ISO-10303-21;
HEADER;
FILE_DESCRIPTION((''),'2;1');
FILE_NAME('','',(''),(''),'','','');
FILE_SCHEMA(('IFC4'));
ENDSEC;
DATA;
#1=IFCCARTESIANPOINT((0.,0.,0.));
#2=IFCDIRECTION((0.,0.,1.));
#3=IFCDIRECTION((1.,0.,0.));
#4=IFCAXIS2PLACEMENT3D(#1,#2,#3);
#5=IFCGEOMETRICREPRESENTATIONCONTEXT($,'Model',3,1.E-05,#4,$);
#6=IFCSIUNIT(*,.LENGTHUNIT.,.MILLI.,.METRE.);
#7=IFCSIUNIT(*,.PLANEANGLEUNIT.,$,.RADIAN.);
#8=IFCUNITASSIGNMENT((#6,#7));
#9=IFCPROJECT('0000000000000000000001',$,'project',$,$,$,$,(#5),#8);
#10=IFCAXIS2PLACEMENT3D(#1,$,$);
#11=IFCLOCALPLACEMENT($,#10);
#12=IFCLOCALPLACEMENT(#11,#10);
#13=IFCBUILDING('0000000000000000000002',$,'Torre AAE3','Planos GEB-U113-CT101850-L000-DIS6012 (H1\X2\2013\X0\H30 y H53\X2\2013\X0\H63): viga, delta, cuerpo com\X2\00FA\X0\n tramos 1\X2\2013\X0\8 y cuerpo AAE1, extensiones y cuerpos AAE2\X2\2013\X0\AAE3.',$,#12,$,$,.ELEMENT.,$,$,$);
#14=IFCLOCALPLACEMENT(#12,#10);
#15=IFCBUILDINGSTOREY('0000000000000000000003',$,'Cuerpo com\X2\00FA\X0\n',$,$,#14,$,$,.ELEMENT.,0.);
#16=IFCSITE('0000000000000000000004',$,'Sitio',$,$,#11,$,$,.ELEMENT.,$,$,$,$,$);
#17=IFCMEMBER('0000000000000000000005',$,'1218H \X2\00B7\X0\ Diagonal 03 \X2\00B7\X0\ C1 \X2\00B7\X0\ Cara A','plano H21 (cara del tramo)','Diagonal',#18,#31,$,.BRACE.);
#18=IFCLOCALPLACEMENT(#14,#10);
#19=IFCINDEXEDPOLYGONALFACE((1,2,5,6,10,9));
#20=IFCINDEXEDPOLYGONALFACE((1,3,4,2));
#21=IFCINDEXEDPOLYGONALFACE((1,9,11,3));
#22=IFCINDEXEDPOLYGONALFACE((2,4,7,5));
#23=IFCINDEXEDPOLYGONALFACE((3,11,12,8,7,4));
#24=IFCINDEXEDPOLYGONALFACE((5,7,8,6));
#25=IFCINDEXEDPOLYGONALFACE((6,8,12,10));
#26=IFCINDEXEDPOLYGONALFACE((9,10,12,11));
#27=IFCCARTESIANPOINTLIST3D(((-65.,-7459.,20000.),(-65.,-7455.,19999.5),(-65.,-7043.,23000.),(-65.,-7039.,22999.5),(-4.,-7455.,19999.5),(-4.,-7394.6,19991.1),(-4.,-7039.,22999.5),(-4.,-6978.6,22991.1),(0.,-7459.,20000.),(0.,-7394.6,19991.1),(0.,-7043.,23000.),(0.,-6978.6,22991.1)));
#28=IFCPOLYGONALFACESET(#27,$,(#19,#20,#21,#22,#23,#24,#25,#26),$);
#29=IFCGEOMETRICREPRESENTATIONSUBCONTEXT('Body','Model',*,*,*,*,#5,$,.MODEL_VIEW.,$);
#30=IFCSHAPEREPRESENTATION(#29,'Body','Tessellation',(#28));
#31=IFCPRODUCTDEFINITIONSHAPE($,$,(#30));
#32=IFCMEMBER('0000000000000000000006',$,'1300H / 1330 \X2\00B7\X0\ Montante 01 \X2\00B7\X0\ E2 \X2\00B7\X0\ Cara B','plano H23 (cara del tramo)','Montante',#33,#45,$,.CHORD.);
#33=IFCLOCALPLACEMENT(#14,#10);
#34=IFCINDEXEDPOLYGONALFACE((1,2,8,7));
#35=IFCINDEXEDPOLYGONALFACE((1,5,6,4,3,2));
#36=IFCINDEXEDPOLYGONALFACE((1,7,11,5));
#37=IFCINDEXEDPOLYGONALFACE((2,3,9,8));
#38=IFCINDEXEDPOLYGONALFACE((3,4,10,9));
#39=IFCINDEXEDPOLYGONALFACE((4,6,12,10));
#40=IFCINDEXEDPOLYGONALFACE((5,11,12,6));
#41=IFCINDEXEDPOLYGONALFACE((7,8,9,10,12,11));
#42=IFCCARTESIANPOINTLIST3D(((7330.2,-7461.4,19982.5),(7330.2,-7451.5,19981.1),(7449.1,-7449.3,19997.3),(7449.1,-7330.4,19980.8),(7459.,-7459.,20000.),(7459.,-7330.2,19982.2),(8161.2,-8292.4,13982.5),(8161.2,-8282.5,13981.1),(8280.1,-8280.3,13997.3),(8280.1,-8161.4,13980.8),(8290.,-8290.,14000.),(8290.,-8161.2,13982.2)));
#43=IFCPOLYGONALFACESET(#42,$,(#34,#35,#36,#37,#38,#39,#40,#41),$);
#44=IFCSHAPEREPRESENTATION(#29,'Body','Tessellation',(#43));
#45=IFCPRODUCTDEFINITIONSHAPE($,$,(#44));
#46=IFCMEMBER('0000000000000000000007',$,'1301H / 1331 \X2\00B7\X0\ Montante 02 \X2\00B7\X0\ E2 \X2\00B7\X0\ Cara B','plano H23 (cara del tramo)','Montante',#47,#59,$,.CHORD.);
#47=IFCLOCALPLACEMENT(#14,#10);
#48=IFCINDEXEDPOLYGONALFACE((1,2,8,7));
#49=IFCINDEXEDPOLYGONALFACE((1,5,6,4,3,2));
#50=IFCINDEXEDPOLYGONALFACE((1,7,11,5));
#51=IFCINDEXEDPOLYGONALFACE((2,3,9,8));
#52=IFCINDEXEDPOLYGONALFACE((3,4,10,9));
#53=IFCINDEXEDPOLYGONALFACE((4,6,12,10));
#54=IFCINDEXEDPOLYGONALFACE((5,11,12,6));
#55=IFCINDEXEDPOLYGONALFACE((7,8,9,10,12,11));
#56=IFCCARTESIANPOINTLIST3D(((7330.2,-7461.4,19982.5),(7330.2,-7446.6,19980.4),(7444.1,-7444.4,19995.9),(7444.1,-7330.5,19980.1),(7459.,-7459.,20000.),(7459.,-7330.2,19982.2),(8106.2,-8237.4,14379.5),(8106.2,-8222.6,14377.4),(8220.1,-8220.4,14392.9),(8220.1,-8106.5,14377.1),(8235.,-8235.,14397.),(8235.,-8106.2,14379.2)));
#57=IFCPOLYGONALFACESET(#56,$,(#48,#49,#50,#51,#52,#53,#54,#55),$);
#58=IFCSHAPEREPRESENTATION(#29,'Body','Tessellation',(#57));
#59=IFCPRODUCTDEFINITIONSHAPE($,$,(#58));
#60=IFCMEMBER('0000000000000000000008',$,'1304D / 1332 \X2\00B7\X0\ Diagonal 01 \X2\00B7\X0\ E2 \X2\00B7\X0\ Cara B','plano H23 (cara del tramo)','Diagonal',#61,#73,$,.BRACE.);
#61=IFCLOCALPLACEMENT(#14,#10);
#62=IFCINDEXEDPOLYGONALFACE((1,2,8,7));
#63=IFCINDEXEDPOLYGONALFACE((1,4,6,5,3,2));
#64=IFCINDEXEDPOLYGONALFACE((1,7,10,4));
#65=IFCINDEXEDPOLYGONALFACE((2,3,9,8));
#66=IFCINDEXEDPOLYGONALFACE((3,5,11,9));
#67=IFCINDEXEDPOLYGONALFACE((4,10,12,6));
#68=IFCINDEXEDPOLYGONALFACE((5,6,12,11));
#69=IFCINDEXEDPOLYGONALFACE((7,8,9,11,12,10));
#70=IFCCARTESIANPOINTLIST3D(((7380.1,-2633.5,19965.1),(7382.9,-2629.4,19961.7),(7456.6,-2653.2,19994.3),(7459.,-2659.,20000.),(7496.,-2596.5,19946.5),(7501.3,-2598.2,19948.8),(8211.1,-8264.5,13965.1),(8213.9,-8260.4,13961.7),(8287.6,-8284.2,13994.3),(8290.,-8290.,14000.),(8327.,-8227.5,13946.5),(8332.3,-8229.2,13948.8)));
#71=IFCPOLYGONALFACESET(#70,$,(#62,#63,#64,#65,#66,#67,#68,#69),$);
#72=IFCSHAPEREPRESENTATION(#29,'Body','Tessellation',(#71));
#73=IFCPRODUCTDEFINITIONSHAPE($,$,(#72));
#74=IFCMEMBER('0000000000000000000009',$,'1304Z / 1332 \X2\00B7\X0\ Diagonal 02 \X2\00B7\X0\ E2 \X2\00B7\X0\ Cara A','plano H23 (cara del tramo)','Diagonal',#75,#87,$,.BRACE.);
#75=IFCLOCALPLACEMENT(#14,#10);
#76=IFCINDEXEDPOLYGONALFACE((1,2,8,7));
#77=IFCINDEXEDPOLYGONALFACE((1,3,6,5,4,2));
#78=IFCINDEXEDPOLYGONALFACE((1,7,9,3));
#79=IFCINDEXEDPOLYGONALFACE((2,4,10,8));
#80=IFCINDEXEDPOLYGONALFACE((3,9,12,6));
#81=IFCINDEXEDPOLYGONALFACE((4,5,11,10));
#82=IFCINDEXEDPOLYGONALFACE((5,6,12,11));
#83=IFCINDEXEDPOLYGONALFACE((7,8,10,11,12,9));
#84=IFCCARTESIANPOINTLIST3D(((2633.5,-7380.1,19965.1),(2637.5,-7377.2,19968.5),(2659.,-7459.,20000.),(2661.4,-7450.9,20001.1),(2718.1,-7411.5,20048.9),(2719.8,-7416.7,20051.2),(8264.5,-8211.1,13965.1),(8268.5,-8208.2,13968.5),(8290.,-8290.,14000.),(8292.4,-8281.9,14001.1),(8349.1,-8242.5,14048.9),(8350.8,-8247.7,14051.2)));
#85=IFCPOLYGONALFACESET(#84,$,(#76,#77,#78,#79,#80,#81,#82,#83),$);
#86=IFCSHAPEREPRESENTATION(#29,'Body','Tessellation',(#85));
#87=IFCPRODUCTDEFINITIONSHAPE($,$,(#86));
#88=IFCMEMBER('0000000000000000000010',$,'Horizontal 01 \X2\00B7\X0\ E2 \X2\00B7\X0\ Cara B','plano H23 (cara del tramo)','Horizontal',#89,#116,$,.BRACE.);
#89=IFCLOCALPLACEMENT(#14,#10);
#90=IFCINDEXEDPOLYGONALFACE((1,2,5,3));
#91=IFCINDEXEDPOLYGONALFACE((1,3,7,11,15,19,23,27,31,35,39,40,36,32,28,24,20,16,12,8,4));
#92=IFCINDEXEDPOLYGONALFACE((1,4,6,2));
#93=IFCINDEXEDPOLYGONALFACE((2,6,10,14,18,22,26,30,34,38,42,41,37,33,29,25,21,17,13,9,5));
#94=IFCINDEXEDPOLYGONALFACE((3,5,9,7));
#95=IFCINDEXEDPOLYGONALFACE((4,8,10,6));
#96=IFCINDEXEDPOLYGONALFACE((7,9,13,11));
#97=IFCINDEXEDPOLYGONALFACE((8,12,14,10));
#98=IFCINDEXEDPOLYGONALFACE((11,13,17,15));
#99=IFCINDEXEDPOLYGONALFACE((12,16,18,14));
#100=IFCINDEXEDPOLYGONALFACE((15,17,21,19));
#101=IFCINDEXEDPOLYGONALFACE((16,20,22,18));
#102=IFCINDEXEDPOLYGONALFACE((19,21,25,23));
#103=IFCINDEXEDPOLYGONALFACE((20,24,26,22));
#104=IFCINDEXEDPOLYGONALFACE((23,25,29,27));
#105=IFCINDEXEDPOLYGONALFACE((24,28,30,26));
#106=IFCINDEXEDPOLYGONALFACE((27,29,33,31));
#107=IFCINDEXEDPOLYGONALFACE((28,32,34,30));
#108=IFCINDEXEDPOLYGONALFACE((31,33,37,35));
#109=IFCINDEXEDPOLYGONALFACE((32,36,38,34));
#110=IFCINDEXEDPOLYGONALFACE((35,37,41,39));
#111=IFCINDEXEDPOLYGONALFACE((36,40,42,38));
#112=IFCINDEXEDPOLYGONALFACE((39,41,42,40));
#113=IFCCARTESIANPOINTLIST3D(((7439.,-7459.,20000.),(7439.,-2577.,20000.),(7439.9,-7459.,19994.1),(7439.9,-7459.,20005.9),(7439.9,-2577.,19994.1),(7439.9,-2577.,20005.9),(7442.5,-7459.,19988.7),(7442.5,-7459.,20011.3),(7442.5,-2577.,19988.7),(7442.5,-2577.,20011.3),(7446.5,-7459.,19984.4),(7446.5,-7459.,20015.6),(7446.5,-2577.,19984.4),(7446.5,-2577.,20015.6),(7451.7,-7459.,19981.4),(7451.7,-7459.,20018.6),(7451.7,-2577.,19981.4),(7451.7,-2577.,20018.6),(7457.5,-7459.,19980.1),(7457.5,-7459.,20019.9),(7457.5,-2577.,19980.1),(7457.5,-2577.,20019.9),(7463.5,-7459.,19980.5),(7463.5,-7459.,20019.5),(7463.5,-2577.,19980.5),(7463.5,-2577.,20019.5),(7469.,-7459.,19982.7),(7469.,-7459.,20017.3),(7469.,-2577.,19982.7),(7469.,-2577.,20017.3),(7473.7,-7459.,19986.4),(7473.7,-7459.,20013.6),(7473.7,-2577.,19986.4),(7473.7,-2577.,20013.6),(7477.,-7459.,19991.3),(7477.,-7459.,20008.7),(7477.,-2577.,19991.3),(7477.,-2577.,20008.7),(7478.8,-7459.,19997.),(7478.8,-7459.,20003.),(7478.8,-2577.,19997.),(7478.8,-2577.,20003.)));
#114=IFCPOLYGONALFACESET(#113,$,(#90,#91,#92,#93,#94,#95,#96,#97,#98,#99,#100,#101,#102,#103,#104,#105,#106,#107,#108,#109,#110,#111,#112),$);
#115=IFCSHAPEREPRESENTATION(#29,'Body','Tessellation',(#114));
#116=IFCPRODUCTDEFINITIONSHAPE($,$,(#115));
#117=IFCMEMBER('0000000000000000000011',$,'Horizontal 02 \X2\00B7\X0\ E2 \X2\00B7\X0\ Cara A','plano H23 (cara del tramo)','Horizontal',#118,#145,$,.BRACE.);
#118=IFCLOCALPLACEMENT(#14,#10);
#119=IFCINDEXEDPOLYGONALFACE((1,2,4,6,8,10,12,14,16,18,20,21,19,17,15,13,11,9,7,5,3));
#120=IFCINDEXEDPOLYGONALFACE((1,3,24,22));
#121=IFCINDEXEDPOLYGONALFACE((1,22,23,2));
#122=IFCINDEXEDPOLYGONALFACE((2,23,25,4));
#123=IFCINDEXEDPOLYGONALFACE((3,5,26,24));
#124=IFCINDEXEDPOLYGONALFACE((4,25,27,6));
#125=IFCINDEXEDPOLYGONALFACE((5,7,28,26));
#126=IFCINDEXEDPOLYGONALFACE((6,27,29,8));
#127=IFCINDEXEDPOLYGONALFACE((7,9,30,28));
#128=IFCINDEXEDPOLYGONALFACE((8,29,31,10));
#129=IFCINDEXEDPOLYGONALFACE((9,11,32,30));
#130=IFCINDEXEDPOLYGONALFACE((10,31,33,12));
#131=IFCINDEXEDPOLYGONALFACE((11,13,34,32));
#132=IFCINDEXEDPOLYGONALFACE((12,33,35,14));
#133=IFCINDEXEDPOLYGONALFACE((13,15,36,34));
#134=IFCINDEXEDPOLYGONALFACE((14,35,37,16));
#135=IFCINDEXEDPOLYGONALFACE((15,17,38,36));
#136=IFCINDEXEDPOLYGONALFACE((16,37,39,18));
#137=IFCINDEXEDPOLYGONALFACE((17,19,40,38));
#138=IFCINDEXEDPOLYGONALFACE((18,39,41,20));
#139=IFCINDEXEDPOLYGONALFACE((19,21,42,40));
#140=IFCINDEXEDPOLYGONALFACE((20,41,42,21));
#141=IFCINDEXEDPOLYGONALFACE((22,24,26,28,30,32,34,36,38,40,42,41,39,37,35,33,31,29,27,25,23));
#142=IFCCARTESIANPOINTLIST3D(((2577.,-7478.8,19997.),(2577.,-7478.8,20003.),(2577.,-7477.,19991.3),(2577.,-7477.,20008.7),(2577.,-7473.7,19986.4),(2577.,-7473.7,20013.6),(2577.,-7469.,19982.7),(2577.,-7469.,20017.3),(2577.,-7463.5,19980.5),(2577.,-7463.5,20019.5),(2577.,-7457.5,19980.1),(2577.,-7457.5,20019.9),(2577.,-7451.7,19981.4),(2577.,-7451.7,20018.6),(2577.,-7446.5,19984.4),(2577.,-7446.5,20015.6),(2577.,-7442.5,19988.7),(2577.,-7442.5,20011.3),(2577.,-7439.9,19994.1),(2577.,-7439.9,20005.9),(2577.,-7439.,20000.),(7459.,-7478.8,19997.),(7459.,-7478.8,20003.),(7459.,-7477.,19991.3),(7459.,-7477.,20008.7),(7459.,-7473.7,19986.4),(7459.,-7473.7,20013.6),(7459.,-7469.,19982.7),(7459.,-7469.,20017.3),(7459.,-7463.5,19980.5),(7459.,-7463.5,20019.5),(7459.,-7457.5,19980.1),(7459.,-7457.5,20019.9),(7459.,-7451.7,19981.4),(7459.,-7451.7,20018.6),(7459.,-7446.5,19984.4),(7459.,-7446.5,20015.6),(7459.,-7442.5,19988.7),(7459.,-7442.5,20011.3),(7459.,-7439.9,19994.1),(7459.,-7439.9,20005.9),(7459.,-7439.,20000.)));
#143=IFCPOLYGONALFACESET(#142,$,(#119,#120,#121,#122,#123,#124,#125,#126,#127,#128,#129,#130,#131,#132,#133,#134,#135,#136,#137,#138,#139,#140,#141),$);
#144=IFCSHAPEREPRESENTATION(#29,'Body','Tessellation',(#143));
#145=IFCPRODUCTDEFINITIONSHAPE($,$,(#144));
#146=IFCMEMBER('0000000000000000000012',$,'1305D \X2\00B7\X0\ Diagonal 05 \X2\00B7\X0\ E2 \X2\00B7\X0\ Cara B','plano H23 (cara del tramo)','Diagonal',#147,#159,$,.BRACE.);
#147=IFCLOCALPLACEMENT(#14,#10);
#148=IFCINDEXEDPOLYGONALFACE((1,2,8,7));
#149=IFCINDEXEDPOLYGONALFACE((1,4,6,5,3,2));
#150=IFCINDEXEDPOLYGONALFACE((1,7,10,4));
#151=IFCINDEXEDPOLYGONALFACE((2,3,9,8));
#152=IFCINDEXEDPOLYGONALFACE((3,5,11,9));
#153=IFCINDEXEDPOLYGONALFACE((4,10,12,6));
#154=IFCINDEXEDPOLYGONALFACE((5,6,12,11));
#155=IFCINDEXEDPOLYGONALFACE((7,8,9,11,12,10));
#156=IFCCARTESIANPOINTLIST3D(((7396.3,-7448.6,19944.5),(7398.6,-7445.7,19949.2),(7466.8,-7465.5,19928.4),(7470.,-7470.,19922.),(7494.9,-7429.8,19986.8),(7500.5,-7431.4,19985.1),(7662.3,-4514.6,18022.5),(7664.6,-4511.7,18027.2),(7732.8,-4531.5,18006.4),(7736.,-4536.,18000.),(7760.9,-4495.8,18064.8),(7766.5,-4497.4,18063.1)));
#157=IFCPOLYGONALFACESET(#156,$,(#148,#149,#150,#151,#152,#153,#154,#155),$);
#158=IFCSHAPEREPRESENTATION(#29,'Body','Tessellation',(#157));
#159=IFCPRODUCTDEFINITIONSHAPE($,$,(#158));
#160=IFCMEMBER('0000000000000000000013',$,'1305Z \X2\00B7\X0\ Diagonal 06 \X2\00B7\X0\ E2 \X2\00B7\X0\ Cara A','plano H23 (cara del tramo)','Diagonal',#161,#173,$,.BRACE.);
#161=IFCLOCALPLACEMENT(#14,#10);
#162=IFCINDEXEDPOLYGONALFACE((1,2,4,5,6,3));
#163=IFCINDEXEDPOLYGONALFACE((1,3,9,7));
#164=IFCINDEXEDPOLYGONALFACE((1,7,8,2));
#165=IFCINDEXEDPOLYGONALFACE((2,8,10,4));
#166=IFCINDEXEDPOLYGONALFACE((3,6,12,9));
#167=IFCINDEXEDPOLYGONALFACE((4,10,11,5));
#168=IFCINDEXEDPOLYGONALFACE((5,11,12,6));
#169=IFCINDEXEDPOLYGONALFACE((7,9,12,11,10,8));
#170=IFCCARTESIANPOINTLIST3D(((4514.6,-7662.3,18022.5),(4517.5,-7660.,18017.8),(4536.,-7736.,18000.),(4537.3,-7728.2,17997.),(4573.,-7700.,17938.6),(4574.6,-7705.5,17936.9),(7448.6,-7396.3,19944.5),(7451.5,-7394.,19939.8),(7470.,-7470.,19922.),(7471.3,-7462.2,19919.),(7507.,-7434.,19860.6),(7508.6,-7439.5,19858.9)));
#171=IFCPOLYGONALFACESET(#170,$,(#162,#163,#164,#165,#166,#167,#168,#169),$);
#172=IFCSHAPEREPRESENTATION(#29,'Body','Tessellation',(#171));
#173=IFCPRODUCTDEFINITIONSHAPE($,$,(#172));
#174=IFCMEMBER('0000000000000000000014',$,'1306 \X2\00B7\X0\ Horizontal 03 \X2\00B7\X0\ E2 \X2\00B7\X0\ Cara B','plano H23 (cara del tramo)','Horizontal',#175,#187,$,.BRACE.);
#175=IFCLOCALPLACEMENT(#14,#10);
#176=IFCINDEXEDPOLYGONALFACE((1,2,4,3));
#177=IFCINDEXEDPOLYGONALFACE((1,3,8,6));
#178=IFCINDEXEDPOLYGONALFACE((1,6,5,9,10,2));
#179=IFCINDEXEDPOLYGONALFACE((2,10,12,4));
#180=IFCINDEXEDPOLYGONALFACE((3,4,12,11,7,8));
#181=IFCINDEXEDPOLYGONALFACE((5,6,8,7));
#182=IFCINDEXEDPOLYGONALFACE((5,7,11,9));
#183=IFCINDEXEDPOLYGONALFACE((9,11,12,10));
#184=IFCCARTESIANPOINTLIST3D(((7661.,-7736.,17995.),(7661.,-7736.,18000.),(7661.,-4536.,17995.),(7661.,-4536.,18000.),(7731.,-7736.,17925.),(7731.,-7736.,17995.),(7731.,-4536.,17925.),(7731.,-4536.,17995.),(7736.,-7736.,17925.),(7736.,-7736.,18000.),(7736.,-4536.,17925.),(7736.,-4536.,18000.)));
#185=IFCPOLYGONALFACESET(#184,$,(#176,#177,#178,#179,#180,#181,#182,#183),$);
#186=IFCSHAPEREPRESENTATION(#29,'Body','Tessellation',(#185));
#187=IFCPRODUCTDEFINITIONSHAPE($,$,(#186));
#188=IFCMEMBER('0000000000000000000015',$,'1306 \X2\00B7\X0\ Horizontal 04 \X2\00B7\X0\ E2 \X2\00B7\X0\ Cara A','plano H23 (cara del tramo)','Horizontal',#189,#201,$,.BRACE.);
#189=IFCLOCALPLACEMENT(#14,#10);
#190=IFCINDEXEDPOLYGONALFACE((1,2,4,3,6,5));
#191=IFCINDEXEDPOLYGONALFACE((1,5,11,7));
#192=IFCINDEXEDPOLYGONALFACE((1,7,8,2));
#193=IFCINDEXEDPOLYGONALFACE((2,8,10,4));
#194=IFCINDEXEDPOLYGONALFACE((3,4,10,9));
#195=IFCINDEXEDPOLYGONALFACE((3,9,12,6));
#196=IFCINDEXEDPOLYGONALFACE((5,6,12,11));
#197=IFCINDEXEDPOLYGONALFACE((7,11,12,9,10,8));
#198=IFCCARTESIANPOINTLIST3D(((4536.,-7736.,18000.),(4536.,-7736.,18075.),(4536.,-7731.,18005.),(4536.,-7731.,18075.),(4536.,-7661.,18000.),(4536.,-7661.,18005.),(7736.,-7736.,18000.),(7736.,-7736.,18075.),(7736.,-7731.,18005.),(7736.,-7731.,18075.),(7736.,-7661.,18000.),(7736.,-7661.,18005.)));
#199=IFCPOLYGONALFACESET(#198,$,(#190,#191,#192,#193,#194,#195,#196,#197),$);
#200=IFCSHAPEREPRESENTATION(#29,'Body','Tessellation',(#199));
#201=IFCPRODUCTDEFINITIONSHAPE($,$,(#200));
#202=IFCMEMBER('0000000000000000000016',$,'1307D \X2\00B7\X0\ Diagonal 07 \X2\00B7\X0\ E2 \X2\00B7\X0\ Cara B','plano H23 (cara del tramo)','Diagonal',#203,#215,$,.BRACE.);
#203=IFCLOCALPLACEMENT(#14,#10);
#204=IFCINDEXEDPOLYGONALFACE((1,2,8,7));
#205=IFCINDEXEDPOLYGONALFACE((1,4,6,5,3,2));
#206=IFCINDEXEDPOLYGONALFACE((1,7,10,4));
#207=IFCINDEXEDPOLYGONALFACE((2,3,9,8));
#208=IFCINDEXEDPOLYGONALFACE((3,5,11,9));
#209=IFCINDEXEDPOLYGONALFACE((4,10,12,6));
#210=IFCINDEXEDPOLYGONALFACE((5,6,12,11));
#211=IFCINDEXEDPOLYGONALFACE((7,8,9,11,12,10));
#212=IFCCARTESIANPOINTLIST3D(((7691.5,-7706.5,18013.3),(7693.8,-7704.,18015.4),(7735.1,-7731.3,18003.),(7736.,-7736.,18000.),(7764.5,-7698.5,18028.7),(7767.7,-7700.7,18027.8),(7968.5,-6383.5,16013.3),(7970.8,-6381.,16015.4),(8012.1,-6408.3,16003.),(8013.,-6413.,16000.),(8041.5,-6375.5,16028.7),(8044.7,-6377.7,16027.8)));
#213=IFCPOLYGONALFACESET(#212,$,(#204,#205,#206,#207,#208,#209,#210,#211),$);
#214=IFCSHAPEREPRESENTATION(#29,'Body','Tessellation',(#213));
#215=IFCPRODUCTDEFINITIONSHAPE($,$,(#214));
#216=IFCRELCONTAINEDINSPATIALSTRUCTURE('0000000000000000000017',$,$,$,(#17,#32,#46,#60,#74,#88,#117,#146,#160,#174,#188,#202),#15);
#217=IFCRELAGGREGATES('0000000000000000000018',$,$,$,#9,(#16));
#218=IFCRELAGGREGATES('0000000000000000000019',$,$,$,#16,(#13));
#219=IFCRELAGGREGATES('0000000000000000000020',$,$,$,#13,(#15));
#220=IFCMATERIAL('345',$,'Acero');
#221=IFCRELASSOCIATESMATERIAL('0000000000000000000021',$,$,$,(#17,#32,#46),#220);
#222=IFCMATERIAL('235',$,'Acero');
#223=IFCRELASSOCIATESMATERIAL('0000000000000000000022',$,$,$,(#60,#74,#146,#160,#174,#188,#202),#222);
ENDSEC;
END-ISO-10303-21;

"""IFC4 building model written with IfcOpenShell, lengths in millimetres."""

from ifc_helpers import new_model, si_unit, frame, frame_2d, origin, origin_with_axes, place, context, subcontext, project, spatial, circle, l_section, extrude, material, element, save


model = new_model("IFC4")

# Units and contexts
model_context = context("Model", 3, precision=1e-05, world=origin_with_axes())
body_context = subcontext(model_context, "Body", "Model", "MODEL_VIEW")
ifc_project = project(units=[si_unit("LENGTHUNIT", "METRE", prefix="MILLI"), si_unit("PLANEANGLEUNIT", "RADIAN")], contexts=[model_context])

# Site, building, storey
site_placement = place(None, origin())
site = spatial("IfcSite", under=ifc_project, at=site_placement, Name="Sitio", CompositionType="ELEMENT")
building_placement = place(site_placement, origin())
building = spatial("IfcBuilding", under=site, at=building_placement, Name="Torre AAE3", Description="Planos GEB-U113-CT101850-L000-DIS6012 (H1–H30 y H53–H63): viga, delta, cuerpo común tramos 1–8 y cuerpo AAE1, extensiones y cuerpos AAE2–AAE3.", CompositionType="ELEMENT")
storey_placement = place(building_placement, origin())
storey = spatial("IfcBuildingStorey", under=building, at=storey_placement, Name="Cuerpo común", CompositionType="ELEMENT", Elevation=0.0)

# Members
ifc_material_1 = material(Name="345", Category="Acero")
member_1_placement = place(storey_placement, frame((0.0, -7459.0, 20000.0), z_axis=(0.0, 0.137352, 0.990522), x_axis=(0.0, 0.990522, -0.137352)))
element("IfcMember", 1, at=member_1_placement, inside=storey, material=ifc_material_1, Name="1218H · Diagonal 03 · C1 · Cara A", Description="plano H21 (cara del tramo)", ObjectType="Diagonal", PredefinedType="BRACE", context=body_context, shape_type="SweptSolid", body=[
    extrude(l_section(Depth=65.0, Width=65.0, Thickness=4.0, at=frame_2d((32.5, 32.5))), None, (0.0, 0.0, 1.0), 3028.7),
])
member_2_placement = place(storey_placement, frame((7459.0, -7459.0, 20000.0), z_axis=(0.135917, -0.135917, -0.981353), x_axis=(-0.99072, -0.018647, -0.134632)))
element("IfcMember", 2, at=member_2_placement, inside=storey, material=ifc_material_1, Name="1300H / 1330 · Montante 01 · E2 · Cara B", Description="plano H23 (cara del tramo)", ObjectType="Montante", PredefinedType="CHORD", context=body_context, shape_type="SweptSolid", body=[
    extrude(l_section(Depth=130.0, Width=130.0, Thickness=10.0, at=frame_2d((65.0, 65.0))), None, (0.0, 0.0, 1.0), 6114.0),
])
member_3_placement = place(storey_placement, frame((7459.0, -7459.0, 20000.0), z_axis=(0.135915, -0.135915, -0.981353), x_axis=(-0.990721, -0.018646, -0.13463)))
element("IfcMember", 3, at=member_3_placement, inside=storey, material=ifc_material_1, Name="1301H / 1331 · Montante 02 · E2 · Cara B", Description="plano H23 (cara del tramo)", ObjectType="Montante", PredefinedType="CHORD", context=body_context, shape_type="SweptSolid", body=[
    extrude(l_section(Depth=130.0, Width=130.0, Thickness=15.0, at=frame_2d((65.0, 65.0))), None, (0.0, 0.0, 1.0), 5709.5),
])
ifc_material_2 = material(Name="235", Category="Acero")
for number, where, z_axis, x_axis, name in (
    (4, (7459.0, -2659.0, 20000.0), (0.100479, -0.680866, -0.725483), (-0.877196, 0.283466, -0.387524), "1304D / 1332 · Diagonal 01 · E2 · Cara B"),
    (5, (2659.0, -7459.0, 20000.0), (0.680866, -0.100479, -0.725483), (-0.283466, 0.877196, -0.387524), "1304Z / 1332 · Diagonal 02 · E2 · Cara A"),
):
    element("IfcMember", number, at=place(storey_placement, frame(where, z_axis=z_axis, x_axis=x_axis)), inside=storey, material=ifc_material_2, Name=name, Description="plano H23 (cara del tramo)", ObjectType="Diagonal", PredefinedType="BRACE", context=body_context, shape_type="SweptSolid", body=[
        extrude(l_section(Depth=90.0, Width=90.0, Thickness=6.0, at=frame_2d((45.0, 45.0))), None, (0.0, 0.0, 1.0), 8270.4),
    ])
for number, where, z_axis, x_axis, name in (
    (6, (7459.0, -7459.0, 20000.0), (0.0, 1.0, 0.0), (-1.0, 0.0, 0.0), "Horizontal 01 · E2 · Cara B"),
    (7, (7459.0, -7459.0, 20000.0), (-1.0, 0.0, 0.0), (0.0, 1.0, 0.0), "Horizontal 02 · E2 · Cara A"),
):
    element("IfcMember", number, at=place(storey_placement, frame(where, z_axis=z_axis, x_axis=x_axis)), inside=storey, Name=name, Description="plano H23 (cara del tramo)", ObjectType="Horizontal", PredefinedType="BRACE", context=body_context, shape_type="SweptSolid", body=[
        extrude(circle(Radius=20.0), None, (0.0, 0.0, 1.0), 4882.0),
    ])
for number, where, z_axis, x_axis, name in (
    (8, (7470.0, -7470.0, 19922.0), (0.075621, 0.834102, -0.546402), (-0.921564, 0.267724, 0.281148), "1305D · Diagonal 05 · E2 · Cara B"),
    (9, (7470.0, -7470.0, 19922.0), (-0.834102, -0.075621, -0.546402), (-0.267724, 0.921564, 0.281148), "1305Z · Diagonal 06 · E2 · Cara A"),
):
    element("IfcMember", number, at=place(storey_placement, frame(where, z_axis=z_axis, x_axis=x_axis)), inside=storey, material=ifc_material_2, Name=name, Description="plano H23 (cara del tramo)", ObjectType="Diagonal", PredefinedType="BRACE", context=body_context, shape_type="SweptSolid", body=[
        extrude(l_section(Depth=80.0, Width=80.0, Thickness=6.0, at=frame_2d((40.0, 40.0))), None, (0.0, 0.0, 1.0), 3517.6),
    ])
for number, where, z_axis, x_axis, name in (
    (10, (7736.0, -4536.0, 18000.0), (0.0, -1.0, 0.0), (-1.0, 0.0, 0.0), "1306 · Horizontal 03 · E2 · Cara B"),
    (11, (4536.0, -7736.0, 18000.0), (1.0, 0.0, 0.0), (0.0, 1.0, 0.0), "1306 · Horizontal 04 · E2 · Cara A"),
):
    element("IfcMember", number, at=place(storey_placement, frame(where, z_axis=z_axis, x_axis=x_axis)), inside=storey, material=ifc_material_2, Name=name, Description="plano H23 (cara del tramo)", ObjectType="Horizontal", PredefinedType="BRACE", context=body_context, shape_type="SweptSolid", body=[
        extrude(l_section(Depth=75.0, Width=75.0, Thickness=5.0, at=frame_2d((37.5, 37.5))), None, (0.0, 0.0, 1.0), 3200.0),
    ])
for number, where, z_axis, x_axis, name in (
    (12, (7736.0, -7736.0, 18000.0), (0.114751, 0.548069, -0.828524), (-0.808683, 0.535928, 0.242514), "1307D · Diagonal 07 · E2 · Cara B"),
):
    element("IfcMember", number, at=place(storey_placement, frame(where, z_axis=z_axis, x_axis=x_axis)), inside=storey, material=ifc_material_2, Name=name, Description="plano H23 (cara del tramo)", ObjectType="Diagonal", PredefinedType="BRACE", context=body_context, shape_type="SweptSolid", body=[
        extrude(l_section(Depth=55.0, Width=55.0, Thickness=4.0, at=frame_2d((27.5, 27.5))), None, (0.0, 0.0, 1.0), 2413.9),
    ])

save(model, "model.ifc")
